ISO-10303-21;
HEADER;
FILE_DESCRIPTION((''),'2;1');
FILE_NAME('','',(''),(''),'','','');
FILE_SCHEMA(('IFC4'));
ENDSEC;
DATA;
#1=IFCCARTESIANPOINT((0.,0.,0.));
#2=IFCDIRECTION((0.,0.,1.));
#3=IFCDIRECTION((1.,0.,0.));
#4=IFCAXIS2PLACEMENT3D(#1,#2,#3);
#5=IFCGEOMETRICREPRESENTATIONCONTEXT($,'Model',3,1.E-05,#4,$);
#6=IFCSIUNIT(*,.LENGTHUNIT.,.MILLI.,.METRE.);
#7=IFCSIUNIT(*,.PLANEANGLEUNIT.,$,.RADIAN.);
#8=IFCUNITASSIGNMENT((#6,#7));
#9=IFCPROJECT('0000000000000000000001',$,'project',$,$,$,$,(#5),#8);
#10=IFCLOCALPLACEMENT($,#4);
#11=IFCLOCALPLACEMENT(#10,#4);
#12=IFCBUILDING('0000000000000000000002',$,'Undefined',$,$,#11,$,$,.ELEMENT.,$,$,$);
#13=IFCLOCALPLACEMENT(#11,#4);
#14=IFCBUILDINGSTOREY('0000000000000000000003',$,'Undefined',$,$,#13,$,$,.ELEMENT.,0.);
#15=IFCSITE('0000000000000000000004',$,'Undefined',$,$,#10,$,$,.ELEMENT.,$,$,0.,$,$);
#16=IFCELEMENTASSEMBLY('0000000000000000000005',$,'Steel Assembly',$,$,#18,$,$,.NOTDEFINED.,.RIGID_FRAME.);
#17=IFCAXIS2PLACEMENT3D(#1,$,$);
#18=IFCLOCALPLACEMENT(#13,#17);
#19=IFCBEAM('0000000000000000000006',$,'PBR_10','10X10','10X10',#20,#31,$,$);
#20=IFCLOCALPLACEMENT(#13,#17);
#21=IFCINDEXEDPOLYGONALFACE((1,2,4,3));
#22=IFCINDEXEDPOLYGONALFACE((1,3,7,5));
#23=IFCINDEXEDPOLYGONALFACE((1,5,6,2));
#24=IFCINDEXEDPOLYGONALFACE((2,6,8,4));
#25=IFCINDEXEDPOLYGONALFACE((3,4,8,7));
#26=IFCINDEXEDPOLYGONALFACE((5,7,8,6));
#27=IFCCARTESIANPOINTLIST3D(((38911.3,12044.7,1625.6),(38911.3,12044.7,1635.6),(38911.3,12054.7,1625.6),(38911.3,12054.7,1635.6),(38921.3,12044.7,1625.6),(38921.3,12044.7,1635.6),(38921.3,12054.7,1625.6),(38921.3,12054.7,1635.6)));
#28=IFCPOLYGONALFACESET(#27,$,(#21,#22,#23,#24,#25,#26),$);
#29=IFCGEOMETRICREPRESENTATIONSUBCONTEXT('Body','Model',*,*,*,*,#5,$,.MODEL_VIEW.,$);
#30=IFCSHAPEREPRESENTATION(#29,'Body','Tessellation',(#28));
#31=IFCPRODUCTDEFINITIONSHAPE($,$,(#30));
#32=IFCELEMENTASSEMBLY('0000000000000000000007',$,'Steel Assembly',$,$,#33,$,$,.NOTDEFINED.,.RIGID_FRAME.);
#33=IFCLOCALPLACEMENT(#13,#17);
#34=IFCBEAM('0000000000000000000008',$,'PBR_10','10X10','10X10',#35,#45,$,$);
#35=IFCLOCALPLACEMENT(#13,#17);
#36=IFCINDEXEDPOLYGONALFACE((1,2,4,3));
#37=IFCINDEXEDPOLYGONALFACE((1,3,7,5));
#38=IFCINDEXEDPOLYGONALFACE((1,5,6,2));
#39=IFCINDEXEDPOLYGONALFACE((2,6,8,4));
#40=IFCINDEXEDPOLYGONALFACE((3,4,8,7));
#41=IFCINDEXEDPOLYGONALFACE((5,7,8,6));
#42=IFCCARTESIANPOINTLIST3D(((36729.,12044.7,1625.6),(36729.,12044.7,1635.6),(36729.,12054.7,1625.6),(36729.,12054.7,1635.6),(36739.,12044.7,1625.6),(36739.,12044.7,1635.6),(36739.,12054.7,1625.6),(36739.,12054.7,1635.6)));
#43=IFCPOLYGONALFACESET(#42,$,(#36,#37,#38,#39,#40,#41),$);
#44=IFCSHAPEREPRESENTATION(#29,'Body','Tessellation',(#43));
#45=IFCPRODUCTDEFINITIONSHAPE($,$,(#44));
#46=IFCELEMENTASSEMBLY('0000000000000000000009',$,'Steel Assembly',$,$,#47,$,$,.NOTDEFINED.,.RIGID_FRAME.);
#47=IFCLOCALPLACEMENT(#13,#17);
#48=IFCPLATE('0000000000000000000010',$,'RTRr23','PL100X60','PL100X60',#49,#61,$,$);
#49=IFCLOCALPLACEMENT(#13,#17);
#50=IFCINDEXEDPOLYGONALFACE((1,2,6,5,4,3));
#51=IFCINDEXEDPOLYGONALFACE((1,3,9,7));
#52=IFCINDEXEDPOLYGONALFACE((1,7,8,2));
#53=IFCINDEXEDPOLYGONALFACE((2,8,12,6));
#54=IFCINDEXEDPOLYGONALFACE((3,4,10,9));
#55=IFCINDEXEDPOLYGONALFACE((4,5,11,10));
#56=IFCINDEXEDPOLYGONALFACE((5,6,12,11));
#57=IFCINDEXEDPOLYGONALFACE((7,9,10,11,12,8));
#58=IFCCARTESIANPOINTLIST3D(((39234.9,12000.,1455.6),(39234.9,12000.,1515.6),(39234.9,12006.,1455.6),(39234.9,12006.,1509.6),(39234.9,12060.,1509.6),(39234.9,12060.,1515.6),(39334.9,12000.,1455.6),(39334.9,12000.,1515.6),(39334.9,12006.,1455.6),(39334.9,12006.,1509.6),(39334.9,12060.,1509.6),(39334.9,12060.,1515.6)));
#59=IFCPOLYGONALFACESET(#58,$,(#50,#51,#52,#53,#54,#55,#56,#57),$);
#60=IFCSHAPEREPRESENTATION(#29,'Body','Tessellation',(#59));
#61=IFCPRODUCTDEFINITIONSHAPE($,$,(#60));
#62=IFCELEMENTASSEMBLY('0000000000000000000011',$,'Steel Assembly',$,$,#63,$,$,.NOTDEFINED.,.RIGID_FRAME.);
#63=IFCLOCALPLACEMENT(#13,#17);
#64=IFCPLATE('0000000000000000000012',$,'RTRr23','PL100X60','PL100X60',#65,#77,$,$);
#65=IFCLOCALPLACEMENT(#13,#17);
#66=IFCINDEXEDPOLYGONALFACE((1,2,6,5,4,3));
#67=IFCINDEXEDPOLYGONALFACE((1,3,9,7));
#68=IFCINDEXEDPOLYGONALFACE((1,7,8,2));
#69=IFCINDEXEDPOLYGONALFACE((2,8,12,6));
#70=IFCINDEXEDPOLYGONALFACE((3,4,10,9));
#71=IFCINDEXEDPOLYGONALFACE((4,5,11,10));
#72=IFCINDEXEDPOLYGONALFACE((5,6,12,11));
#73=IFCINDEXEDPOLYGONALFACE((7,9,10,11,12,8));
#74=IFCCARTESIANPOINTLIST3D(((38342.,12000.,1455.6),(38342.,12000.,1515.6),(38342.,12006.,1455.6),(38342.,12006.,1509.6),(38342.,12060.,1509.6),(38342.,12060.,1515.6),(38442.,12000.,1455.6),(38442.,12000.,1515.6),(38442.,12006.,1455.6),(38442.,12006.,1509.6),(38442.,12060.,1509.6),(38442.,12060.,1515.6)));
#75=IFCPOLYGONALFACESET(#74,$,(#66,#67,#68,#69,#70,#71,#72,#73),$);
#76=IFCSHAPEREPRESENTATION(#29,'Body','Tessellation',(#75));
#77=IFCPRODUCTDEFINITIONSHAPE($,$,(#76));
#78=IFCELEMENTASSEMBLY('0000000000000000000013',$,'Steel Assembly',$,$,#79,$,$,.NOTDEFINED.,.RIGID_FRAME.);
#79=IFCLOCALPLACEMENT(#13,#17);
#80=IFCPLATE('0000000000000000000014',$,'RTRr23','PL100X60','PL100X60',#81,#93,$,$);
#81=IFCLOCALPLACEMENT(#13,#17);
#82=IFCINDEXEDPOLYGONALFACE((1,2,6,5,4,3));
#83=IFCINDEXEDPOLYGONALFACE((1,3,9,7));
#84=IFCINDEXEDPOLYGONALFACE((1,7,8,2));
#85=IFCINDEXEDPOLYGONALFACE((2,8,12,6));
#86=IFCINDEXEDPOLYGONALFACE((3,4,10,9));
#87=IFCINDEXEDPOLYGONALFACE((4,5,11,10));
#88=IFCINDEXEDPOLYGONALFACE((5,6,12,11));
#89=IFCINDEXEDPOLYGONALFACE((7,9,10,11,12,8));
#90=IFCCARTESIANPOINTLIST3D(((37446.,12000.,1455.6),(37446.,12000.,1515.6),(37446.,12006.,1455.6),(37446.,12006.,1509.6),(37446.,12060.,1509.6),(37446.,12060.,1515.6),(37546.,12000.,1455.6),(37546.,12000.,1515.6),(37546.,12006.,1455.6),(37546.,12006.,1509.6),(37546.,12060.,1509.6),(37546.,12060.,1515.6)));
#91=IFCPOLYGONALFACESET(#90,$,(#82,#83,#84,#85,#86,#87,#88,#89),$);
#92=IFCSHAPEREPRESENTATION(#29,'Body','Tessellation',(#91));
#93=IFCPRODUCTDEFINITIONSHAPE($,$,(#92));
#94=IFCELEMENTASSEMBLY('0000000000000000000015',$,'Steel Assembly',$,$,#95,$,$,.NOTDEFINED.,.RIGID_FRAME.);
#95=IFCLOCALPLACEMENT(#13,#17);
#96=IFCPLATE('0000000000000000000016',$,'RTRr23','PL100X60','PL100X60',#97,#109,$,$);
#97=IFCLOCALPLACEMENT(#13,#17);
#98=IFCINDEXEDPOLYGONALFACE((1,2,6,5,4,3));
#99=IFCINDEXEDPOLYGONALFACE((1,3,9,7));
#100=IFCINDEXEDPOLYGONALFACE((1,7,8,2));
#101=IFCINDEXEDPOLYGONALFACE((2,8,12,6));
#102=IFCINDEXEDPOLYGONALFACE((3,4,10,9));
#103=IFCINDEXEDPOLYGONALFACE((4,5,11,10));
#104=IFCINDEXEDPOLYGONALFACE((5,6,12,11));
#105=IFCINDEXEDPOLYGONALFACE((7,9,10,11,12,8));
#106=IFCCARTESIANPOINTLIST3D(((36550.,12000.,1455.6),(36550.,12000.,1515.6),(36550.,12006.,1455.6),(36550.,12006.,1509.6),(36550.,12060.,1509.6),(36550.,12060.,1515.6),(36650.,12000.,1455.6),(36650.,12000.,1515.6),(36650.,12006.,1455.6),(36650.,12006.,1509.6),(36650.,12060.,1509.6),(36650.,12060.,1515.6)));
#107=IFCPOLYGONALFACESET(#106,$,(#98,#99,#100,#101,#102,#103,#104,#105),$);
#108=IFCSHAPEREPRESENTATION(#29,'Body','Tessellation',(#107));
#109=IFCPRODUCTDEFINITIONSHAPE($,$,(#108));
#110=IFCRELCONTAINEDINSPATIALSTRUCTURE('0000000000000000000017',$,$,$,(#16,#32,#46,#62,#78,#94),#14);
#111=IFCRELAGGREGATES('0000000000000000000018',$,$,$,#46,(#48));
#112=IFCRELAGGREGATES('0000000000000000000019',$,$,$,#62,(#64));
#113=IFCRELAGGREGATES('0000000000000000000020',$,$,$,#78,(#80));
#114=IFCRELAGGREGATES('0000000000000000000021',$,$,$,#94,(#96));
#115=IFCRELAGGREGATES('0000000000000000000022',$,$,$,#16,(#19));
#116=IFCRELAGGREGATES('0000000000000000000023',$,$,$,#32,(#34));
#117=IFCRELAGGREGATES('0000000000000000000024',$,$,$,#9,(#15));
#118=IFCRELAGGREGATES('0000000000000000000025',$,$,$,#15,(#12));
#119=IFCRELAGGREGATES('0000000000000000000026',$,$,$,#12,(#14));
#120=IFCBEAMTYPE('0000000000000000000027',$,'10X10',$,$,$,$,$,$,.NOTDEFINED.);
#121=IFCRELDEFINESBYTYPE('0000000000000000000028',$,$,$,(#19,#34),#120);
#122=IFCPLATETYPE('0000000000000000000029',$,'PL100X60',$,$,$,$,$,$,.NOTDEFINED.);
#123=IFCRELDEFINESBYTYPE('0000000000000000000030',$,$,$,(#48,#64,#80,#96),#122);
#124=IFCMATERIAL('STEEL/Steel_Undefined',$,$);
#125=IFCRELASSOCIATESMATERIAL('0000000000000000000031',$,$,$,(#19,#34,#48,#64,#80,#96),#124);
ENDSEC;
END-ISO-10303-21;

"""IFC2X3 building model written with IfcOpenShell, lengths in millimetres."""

from ifc_helpers import new_model, si_unit, frame, origin_with_axes, origin_2d_with_axis, place, context, subcontext, project, spatial, polyline, rectangle, outline, extrude, material, type_object, element, aggregate, save


model = new_model("IFC2X3")

# Units and contexts
model_context = context("Model", 3, precision=1e-05, world=origin_with_axes())
body_context = subcontext(model_context, "Body", "Model", "MODEL_VIEW")
ifc_project = project(units=[si_unit("LENGTHUNIT", "METRE", prefix="MILLI"), si_unit("PLANEANGLEUNIT", "RADIAN")], contexts=[model_context])

# Site, building, storey
site_placement = place(None, origin_with_axes())
site = spatial("IfcSite", under=ifc_project, at=site_placement, Name="Undefined", CompositionType="ELEMENT", RefElevation=0.0)
building_placement = place(site_placement, origin_with_axes())
building = spatial("IfcBuilding", under=site, at=building_placement, Name="Undefined", CompositionType="ELEMENT")
storey_placement = place(building_placement, origin_with_axes())
storey = spatial("IfcBuildingStorey", under=building, at=storey_placement, Name="Undefined", CompositionType="ELEMENT", Elevation=0.0)

# Element assemblies, beams
assembly_1_placement = place(storey_placement, origin_with_axes())
assembly_1 = element("IfcElementAssembly", 1, at=assembly_1_placement, inside=storey, Name="Steel Assembly", AssemblyPlace="NOTDEFINED", PredefinedType="RIGID_FRAME")
ifc_material_1 = material(Name="STEEL/Steel_Undefined")
beam_type = type_object("IfcBeamType", Name="10X10", PredefinedType="NOTDEFINED")
beam_1_placement = place(assembly_1_placement, frame((38911.3, 12049.7, 1630.6), z_axis=(0.0, 0.0, 1.0), x_axis=(1.0, 0.0, 0.0)))
beam_1 = element("IfcBeam", 2, at=beam_1_placement, type_object=beam_type, material=ifc_material_1, Name="PBR_10", Description="10X10", ObjectType="10X10", context=body_context, shape_type="SweptSolid", body=[
    extrude(rectangle(XDim=10.0, YDim=10.0, at=origin_2d_with_axis()), frame((10.0, 0.0, 0.0), z_axis=(-1.0, 0.000001, 0.0), x_axis=(0.0, -1.0, 0.0)), (0.0, 0.0, 1.0), 10.0),
])
assembly_2_placement = place(storey_placement, origin_with_axes())
assembly_2 = element("IfcElementAssembly", 3, at=assembly_2_placement, inside=storey, Name="Steel Assembly", AssemblyPlace="NOTDEFINED", PredefinedType="RIGID_FRAME")
beam_2_placement = place(assembly_2_placement, frame((36739.0, 12049.7, 1630.6), z_axis=(0.0, 0.0, 1.0), x_axis=(-1.0, 0.000001, 0.0)))
beam_2 = element("IfcBeam", 4, at=beam_2_placement, type_object=beam_type, material=ifc_material_1, Name="PBR_10", Description="10X10", ObjectType="10X10", context=body_context, shape_type="SweptSolid", body=[
    extrude(rectangle(XDim=10.0, YDim=10.0, at=origin_2d_with_axis()), frame((10.0, 0.0, 0.0), z_axis=(-1.0, 0.000001, 0.0), x_axis=(0.0, -1.0, 0.0)), (0.0, 0.0, 1.0), 10.0),
])

# Element assemblies, plates
assembly_3_placement = place(storey_placement, origin_with_axes())
assembly_3 = element("IfcElementAssembly", 5, at=assembly_3_placement, inside=storey, Name="Steel Assembly", AssemblyPlace="NOTDEFINED", PredefinedType="RIGID_FRAME")
plate_type = type_object("IfcPlateType", Name="PL100X60", PredefinedType="NOTDEFINED")
plate_1_placement = place(assembly_3_placement, frame((39284.9, 12000.0, 1515.6), z_axis=(-1.0, 0.000001, 0.0), x_axis=(0.0, 1.0, 0.0)))
plate_1 = element("IfcPlate", 6, at=plate_1_placement, type_object=plate_type, material=ifc_material_1, Name="RTRr23", Description="PL100X60", ObjectType="PL100X60", context=body_context, shape_type="SweptSolid", body=[
    extrude(outline(polyline([(0.0, 0.0), (60.0, 0.0), (60.0, 6.0), (6.0, 6.0), (6.0, 60.0), (0.0, 60.0), (0.0, 0.0)])), frame((0.0, 0.0, -50.0), z_axis=(0.0, 0.0, 1.0), x_axis=(1.0, 0.0, 0.0)), (0.0, 0.0, 1.0), 100.0),
])
assembly_4_placement = place(storey_placement, origin_with_axes())
assembly_4 = element("IfcElementAssembly", 7, at=assembly_4_placement, inside=storey, Name="Steel Assembly", AssemblyPlace="NOTDEFINED", PredefinedType="RIGID_FRAME")
plate_2_placement = place(assembly_4_placement, frame((38392.0, 12000.0, 1515.6), z_axis=(-1.0, 0.000001, 0.0), x_axis=(0.0, 1.0, 0.0)))
plate_2 = element("IfcPlate", 8, at=plate_2_placement, type_object=plate_type, material=ifc_material_1, Name="RTRr23", Description="PL100X60", ObjectType="PL100X60", context=body_context, shape_type="SweptSolid", body=[
    extrude(outline(polyline([(0.0, 0.0), (60.0, 0.0), (60.0, 6.0), (6.0, 6.0), (6.0, 60.0), (0.0, 60.0), (0.0, 0.0)])), frame((0.0, 0.0, -50.0), z_axis=(0.0, 0.0, 1.0), x_axis=(1.0, 0.0, 0.0)), (0.0, 0.0, 1.0), 100.0),
])
assembly_5_placement = place(storey_placement, origin_with_axes())
assembly_5 = element("IfcElementAssembly", 9, at=assembly_5_placement, inside=storey, Name="Steel Assembly", AssemblyPlace="NOTDEFINED", PredefinedType="RIGID_FRAME")
plate_3_placement = place(assembly_5_placement, frame((37496.0, 12000.0, 1515.6), z_axis=(-1.0, 0.000001, 0.0), x_axis=(0.0, 1.0, 0.0)))
plate_3 = element("IfcPlate", 10, at=plate_3_placement, type_object=plate_type, material=ifc_material_1, Name="RTRr23", Description="PL100X60", ObjectType="PL100X60", context=body_context, shape_type="SweptSolid", body=[
    extrude(outline(polyline([(0.0, 0.0), (60.0, 0.0), (60.0, 6.0), (6.0, 6.0), (6.0, 60.0), (0.0, 60.0), (0.0, 0.0)])), frame((0.0, 0.0, -50.0), z_axis=(0.0, 0.0, 1.0), x_axis=(1.0, 0.0, 0.0)), (0.0, 0.0, 1.0), 100.0),
])
assembly_6_placement = place(storey_placement, origin_with_axes())
assembly_6 = element("IfcElementAssembly", 11, at=assembly_6_placement, inside=storey, Name="Steel Assembly", AssemblyPlace="NOTDEFINED", PredefinedType="RIGID_FRAME")
plate_4_placement = place(assembly_6_placement, frame((36600.0, 12000.0, 1515.6), z_axis=(-1.0, 0.000001, 0.0), x_axis=(0.0, 1.0, 0.0)))
plate_4 = element("IfcPlate", 12, at=plate_4_placement, type_object=plate_type, material=ifc_material_1, Name="RTRr23", Description="PL100X60", ObjectType="PL100X60", context=body_context, shape_type="SweptSolid", body=[
    extrude(outline(polyline([(0.0, 0.0), (60.0, 0.0), (60.0, 6.0), (6.0, 6.0), (6.0, 60.0), (0.0, 60.0), (0.0, 0.0)])), frame((0.0, 0.0, -50.0), z_axis=(0.0, 0.0, 1.0), x_axis=(1.0, 0.0, 0.0)), (0.0, 0.0, 1.0), 100.0),
])

aggregate(assembly_3, [plate_1])
aggregate(assembly_4, [plate_2])
aggregate(assembly_5, [plate_3])
aggregate(assembly_6, [plate_4])
aggregate(assembly_1, [beam_1])
aggregate(assembly_2, [beam_2])

save(model, "model.ifc")
